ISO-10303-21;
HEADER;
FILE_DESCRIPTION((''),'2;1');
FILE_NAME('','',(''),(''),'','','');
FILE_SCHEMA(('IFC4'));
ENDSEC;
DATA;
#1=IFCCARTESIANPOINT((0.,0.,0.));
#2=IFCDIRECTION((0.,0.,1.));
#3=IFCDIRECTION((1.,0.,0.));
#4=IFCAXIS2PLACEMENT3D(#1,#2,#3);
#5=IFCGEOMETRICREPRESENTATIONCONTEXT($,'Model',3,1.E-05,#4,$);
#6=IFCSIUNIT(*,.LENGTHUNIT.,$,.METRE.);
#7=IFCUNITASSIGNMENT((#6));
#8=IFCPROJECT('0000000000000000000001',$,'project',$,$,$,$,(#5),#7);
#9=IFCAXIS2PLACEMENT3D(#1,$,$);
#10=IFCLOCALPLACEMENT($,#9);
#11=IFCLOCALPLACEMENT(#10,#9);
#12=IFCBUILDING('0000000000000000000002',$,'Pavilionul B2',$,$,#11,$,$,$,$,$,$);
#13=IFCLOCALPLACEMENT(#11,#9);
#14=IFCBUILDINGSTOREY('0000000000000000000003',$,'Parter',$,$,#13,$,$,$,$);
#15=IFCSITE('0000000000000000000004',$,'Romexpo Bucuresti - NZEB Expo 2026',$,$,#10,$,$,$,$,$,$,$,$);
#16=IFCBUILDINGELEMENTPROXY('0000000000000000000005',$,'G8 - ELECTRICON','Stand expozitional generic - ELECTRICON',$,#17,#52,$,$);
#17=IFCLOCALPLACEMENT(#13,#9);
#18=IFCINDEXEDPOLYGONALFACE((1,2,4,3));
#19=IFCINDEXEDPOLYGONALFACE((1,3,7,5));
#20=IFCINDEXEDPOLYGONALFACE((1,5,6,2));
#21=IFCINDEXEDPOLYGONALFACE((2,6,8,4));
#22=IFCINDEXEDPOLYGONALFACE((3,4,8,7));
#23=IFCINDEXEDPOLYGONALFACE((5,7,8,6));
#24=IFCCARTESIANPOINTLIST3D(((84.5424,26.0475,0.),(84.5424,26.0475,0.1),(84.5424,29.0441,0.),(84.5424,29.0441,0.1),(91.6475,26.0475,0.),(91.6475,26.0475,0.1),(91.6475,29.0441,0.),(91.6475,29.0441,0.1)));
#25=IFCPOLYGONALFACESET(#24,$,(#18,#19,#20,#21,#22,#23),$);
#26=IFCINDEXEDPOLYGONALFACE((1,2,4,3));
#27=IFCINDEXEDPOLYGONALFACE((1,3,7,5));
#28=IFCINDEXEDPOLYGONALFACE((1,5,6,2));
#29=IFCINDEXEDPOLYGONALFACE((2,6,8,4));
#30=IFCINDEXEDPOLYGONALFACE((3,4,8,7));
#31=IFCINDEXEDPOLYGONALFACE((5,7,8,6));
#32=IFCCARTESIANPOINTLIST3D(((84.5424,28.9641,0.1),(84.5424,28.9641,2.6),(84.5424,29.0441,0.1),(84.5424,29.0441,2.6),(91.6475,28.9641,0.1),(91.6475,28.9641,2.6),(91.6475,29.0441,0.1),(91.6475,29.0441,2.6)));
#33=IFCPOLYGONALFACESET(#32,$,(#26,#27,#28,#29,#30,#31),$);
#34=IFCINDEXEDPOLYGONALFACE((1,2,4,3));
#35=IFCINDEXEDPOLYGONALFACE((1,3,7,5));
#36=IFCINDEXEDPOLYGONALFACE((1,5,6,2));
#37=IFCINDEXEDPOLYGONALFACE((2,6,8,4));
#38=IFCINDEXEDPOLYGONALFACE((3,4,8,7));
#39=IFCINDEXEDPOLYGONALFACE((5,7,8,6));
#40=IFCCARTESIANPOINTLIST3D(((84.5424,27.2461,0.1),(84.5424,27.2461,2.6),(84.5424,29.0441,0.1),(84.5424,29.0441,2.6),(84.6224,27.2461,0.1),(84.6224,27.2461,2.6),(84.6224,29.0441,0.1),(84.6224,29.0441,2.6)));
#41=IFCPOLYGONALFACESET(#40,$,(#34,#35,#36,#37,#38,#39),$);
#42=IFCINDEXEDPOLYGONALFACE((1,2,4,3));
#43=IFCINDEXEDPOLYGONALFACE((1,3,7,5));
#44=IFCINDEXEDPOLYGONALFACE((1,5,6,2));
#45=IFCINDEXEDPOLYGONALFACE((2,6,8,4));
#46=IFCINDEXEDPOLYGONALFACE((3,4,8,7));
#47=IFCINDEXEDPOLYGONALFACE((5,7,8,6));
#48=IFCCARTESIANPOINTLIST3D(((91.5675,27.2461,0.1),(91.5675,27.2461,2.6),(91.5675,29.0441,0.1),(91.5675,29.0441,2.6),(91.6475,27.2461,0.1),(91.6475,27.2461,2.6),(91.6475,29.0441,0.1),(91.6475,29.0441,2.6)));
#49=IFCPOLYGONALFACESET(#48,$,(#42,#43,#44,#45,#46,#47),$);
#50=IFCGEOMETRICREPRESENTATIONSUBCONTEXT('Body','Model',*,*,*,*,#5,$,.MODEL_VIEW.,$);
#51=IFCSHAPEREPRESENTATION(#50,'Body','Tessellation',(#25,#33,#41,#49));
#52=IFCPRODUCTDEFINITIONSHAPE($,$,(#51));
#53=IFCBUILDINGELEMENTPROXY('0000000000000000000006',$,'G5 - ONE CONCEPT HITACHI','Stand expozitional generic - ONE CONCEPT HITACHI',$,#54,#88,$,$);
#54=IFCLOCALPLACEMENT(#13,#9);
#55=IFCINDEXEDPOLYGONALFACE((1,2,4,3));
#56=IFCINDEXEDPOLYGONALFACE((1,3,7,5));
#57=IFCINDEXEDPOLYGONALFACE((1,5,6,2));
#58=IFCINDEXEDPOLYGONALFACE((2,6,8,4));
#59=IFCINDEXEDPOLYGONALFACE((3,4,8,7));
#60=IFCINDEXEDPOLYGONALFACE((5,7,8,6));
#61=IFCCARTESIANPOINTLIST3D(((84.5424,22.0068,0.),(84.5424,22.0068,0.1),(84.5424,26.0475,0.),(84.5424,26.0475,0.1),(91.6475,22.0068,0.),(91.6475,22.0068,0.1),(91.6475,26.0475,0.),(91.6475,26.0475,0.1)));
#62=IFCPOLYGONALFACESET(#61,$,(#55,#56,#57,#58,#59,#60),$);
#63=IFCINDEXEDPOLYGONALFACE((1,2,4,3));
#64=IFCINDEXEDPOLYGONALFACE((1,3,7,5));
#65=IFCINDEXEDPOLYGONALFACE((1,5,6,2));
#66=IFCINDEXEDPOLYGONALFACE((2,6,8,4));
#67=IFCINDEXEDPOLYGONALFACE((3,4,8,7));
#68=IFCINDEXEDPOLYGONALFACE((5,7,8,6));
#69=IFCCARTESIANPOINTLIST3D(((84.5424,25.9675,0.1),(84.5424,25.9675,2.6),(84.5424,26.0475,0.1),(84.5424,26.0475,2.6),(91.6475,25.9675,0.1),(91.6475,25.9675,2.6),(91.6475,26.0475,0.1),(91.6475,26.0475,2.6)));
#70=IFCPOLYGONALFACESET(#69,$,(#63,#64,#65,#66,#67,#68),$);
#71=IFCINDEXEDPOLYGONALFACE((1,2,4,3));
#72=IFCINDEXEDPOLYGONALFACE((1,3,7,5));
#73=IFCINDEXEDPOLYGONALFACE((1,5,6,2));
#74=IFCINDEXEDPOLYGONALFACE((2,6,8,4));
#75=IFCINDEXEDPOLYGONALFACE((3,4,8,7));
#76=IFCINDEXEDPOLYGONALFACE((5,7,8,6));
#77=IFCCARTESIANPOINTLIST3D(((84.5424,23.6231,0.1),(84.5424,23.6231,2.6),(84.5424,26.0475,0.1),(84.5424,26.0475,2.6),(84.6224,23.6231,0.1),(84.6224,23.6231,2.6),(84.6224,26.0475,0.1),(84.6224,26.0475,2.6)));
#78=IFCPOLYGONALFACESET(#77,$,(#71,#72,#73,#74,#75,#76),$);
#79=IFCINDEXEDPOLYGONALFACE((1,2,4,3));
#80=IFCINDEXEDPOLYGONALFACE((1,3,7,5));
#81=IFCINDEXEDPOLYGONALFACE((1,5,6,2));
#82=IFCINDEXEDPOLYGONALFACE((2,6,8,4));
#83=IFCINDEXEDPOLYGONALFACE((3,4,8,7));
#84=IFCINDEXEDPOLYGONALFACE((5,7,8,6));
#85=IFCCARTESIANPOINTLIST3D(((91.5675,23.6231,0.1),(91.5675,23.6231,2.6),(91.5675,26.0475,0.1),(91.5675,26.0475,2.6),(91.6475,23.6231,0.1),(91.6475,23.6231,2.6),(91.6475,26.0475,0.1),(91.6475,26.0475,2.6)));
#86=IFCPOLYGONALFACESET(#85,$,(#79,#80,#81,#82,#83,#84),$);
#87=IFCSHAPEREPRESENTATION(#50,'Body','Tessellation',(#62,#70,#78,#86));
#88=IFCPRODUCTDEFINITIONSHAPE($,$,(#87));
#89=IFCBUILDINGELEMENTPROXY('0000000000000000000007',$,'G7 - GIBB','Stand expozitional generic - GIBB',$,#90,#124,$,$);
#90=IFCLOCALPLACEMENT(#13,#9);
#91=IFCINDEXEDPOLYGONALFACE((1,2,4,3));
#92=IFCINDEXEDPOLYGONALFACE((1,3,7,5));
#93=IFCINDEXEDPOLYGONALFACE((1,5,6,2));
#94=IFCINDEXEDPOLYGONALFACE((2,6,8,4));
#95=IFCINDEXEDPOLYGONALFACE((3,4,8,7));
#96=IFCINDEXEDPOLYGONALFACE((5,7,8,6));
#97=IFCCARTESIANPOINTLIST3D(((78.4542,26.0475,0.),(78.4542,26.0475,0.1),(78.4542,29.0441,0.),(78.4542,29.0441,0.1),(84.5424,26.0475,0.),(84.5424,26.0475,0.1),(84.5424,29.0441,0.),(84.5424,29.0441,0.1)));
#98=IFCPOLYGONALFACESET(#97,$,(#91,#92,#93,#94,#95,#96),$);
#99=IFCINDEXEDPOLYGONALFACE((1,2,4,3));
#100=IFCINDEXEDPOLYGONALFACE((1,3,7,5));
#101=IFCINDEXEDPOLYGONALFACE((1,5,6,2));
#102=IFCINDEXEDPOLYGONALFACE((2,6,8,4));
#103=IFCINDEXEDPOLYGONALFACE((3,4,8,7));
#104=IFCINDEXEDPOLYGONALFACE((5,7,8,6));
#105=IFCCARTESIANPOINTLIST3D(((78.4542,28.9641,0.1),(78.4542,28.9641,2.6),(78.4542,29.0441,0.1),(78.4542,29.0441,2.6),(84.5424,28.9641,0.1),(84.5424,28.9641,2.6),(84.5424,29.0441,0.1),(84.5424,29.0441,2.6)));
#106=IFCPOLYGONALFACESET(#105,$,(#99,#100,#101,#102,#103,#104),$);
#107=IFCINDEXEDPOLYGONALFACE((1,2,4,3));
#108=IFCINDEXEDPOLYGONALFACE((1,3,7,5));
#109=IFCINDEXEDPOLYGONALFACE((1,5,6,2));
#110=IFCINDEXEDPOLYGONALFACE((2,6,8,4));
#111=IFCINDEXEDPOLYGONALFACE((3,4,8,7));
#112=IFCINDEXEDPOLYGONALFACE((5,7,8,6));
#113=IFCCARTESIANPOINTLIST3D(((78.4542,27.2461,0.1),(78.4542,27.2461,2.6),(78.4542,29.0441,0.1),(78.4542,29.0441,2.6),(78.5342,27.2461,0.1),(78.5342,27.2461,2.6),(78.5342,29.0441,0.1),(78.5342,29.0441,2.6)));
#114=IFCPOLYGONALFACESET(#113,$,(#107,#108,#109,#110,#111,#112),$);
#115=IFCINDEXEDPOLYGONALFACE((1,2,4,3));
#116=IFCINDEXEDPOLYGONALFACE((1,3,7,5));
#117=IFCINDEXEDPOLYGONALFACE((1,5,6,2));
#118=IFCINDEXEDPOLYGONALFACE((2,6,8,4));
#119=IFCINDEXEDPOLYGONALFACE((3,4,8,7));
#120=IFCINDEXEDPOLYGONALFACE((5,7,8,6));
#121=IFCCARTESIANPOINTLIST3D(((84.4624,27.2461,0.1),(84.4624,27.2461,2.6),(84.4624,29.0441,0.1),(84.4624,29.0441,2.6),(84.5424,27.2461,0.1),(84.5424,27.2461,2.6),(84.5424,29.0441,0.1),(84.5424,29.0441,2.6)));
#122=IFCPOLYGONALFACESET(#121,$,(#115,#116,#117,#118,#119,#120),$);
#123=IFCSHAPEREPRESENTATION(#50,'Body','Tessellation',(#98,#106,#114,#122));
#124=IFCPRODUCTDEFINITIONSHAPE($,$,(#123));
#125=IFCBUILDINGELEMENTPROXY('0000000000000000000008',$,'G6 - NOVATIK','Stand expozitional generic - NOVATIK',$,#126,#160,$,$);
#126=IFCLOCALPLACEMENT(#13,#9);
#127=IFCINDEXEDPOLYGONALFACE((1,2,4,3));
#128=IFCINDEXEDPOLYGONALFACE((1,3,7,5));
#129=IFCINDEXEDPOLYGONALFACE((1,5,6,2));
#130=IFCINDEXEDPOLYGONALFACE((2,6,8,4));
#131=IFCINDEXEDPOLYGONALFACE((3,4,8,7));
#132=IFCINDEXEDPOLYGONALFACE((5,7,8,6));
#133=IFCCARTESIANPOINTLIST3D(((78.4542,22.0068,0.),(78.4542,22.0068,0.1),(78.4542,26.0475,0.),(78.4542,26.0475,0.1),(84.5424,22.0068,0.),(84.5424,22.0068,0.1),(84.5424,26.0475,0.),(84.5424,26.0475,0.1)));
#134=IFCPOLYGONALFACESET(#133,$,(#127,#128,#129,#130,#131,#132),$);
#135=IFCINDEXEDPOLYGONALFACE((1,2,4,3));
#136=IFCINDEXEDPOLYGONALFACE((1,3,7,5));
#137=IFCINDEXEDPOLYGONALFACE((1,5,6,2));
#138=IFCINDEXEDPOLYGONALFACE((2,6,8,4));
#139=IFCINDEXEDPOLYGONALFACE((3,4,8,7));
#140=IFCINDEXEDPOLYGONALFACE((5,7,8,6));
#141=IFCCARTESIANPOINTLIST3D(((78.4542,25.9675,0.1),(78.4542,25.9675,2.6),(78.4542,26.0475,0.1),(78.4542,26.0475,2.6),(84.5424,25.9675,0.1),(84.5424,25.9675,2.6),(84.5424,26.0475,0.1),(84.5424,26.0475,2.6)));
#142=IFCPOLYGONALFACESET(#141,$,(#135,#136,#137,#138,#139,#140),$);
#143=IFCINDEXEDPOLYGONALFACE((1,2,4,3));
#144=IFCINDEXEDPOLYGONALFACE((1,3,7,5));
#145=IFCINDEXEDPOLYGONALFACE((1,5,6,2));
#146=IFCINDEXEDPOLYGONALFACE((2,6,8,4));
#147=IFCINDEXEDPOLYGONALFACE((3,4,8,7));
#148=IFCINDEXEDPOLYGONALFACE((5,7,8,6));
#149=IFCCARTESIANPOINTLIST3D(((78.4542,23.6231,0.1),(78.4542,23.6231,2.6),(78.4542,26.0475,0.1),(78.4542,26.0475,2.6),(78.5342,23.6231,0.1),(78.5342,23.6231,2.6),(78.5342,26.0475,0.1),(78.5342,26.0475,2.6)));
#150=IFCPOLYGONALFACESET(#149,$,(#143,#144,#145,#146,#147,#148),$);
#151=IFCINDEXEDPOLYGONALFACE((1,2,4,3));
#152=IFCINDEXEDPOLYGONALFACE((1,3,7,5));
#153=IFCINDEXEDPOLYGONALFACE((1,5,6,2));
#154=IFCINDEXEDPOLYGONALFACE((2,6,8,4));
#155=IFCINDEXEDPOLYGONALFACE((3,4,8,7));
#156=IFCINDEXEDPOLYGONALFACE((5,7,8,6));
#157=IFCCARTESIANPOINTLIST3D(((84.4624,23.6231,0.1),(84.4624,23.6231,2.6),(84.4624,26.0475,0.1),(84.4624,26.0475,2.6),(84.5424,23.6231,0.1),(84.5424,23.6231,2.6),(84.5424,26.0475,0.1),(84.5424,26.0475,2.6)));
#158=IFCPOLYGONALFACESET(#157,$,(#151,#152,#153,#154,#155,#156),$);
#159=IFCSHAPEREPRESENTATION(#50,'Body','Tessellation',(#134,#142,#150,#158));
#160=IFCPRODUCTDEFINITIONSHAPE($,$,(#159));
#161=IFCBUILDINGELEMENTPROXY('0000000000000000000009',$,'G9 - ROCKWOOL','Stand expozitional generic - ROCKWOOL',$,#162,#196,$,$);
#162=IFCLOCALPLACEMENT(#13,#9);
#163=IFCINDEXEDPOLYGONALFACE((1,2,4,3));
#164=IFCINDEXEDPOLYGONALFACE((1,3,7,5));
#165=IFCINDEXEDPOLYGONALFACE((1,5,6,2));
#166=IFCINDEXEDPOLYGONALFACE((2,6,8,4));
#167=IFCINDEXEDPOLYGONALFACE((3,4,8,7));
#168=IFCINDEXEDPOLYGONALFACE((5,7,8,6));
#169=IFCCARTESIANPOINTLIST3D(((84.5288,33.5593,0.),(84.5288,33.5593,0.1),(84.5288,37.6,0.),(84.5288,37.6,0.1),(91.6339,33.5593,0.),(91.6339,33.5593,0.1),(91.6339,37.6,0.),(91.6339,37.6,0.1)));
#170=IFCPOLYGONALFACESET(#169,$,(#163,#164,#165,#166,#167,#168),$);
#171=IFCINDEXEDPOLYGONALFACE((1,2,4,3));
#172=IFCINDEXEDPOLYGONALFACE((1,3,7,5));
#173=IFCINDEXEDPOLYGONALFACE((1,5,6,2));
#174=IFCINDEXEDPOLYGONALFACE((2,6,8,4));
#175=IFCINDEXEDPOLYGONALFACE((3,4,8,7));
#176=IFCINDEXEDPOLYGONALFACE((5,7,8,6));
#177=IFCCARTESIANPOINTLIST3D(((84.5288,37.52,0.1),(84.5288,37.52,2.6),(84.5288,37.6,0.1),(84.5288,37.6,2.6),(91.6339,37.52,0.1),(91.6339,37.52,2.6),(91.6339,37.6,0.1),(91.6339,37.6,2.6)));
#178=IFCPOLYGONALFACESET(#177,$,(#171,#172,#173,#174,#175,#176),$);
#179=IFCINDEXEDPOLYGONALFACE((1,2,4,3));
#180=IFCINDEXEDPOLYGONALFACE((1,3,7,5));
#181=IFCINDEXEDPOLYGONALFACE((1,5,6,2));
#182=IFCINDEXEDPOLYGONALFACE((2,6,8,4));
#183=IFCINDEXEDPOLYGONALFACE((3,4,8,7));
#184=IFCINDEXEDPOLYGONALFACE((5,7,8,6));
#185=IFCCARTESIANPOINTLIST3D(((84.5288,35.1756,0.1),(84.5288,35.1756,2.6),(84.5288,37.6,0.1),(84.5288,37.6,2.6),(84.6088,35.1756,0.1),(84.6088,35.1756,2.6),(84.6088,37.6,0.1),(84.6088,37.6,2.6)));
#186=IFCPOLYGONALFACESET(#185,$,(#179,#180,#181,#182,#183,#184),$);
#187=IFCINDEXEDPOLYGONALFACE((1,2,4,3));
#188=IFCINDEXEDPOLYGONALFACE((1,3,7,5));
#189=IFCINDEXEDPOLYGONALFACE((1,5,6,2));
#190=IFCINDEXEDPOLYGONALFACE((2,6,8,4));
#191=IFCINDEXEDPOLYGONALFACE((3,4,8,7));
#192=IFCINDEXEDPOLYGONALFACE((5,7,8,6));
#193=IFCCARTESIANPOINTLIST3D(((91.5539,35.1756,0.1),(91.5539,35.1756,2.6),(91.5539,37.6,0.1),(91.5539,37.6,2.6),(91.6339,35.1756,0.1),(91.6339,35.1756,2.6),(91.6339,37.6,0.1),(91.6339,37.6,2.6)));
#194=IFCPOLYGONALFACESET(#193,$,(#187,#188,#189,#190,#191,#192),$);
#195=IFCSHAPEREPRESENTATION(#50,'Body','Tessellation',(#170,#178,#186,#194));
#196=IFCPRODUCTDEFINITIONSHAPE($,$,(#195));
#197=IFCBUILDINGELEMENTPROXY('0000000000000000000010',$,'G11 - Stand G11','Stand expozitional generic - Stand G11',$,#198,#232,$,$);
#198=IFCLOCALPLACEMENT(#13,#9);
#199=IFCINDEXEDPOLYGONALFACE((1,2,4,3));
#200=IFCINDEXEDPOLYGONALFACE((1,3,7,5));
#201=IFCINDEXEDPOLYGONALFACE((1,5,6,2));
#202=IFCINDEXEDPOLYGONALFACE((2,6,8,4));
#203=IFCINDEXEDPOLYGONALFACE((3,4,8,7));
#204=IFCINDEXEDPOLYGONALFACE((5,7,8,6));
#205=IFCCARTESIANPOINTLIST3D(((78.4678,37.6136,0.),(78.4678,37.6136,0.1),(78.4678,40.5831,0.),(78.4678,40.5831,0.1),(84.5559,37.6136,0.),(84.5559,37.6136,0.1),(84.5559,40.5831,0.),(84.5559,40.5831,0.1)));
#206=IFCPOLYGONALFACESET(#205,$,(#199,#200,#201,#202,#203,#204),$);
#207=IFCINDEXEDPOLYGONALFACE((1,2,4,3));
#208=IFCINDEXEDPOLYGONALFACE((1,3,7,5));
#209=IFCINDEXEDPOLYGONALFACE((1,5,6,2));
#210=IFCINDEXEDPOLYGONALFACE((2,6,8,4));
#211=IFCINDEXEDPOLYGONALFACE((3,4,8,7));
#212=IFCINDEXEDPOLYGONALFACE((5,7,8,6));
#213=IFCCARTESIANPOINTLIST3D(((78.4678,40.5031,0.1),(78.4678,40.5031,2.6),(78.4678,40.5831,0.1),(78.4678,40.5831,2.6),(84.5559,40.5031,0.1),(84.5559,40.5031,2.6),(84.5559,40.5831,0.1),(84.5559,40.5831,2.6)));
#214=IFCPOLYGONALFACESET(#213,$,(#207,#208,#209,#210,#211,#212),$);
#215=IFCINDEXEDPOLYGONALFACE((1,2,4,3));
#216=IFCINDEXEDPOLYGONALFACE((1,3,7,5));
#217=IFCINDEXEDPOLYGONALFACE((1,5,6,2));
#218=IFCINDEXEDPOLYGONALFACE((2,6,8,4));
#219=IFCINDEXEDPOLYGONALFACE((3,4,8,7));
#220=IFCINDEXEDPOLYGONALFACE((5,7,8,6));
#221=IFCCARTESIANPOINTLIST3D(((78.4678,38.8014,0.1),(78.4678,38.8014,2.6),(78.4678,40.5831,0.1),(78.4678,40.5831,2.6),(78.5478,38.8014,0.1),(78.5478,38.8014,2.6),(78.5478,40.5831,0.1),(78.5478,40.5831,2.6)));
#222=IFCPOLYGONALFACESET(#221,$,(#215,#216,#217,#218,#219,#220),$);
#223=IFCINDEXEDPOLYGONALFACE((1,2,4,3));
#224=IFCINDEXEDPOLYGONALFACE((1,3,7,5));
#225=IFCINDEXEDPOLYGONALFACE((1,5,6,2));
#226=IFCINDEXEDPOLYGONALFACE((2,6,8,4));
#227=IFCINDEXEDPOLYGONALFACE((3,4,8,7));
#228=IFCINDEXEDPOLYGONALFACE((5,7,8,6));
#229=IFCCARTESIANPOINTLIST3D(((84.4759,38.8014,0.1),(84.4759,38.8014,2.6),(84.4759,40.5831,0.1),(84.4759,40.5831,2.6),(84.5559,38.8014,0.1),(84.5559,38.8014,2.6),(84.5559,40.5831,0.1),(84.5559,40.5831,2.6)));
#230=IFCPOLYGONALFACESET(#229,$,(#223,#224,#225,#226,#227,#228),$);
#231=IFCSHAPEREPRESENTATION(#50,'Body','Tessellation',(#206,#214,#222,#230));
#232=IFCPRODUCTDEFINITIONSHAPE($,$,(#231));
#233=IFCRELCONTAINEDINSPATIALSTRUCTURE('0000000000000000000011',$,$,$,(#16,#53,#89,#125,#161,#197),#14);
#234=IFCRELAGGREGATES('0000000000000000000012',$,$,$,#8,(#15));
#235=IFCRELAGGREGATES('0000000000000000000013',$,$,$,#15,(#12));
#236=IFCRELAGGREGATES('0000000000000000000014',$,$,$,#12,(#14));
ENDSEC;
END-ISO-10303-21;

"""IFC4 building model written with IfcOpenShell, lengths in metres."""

from ifc_helpers import new_model, si_unit, frame, frame_2d, origin, origin_with_axes, place, context, subcontext, project, spatial, rectangle, extrude, element, save


model = new_model("IFC4")

# Units and contexts
model_context = context("Model", 3, precision=1e-05, world=origin_with_axes())
body_context = subcontext(model_context, "Body", "Model", "MODEL_VIEW")
ifc_project = project(units=[si_unit("LENGTHUNIT", "METRE")], contexts=[model_context])

# Site, building, storey
site_placement = place(None, origin())
site = spatial("IfcSite", under=ifc_project, at=site_placement, Name="Romexpo Bucuresti - NZEB Expo 2026")
building_placement = place(site_placement, origin())
building = spatial("IfcBuilding", under=site, at=building_placement, Name="Pavilionul B2")
storey_placement = place(building_placement, origin())
storey = spatial("IfcBuildingStorey", under=building, at=storey_placement, Name="Parter")

# Building element proxies
proxy_1_placement = place(storey_placement, frame((84.5424, 26.0475, 0.0), z_axis=(0.0, 0.0, 1.0), x_axis=(1.0, 0.0, 0.0)))
element("IfcBuildingElementProxy", 1, at=proxy_1_placement, inside=storey, Name="G8 - ELECTRICON", Description="Stand expozitional generic - ELECTRICON", context=body_context, shape_type="SweptSolid", body=[
    extrude(rectangle(XDim=7.1051, YDim=2.9966, at=frame_2d((3.5525, 1.4983))), origin(), (0.0, 0.0, 1.0), 0.1),
    extrude(rectangle(XDim=7.1051, YDim=0.08, at=frame_2d((3.5525, 2.9566))), frame((0.0, 0.0, 0.1)), (0.0, 0.0, 1.0), 2.5),
    extrude(rectangle(XDim=0.08, YDim=1.798, at=frame_2d((0.04, 2.0976))), frame((0.0, 0.0, 0.1)), (0.0, 0.0, 1.0), 2.5),
    extrude(rectangle(XDim=0.08, YDim=1.798, at=frame_2d((7.0651, 2.0976))), frame((0.0, 0.0, 0.1)), (0.0, 0.0, 1.0), 2.5),
])
proxy_2_placement = place(storey_placement, frame((84.5424, 22.0068, 0.0), z_axis=(0.0, 0.0, 1.0), x_axis=(1.0, 0.0, 0.0)))
element("IfcBuildingElementProxy", 2, at=proxy_2_placement, inside=storey, Name="G5 - ONE CONCEPT HITACHI", Description="Stand expozitional generic - ONE CONCEPT HITACHI", context=body_context, shape_type="SweptSolid", body=[
    extrude(rectangle(XDim=7.1051, YDim=4.0407, at=frame_2d((3.5525, 2.0203))), origin(), (0.0, 0.0, 1.0), 0.1),
    extrude(rectangle(XDim=7.1051, YDim=0.08, at=frame_2d((3.5525, 4.0007))), frame((0.0, 0.0, 0.1)), (0.0, 0.0, 1.0), 2.5),
    extrude(rectangle(XDim=0.08, YDim=2.4244, at=frame_2d((0.04, 2.8285))), frame((0.0, 0.0, 0.1)), (0.0, 0.0, 1.0), 2.5),
    extrude(rectangle(XDim=0.08, YDim=2.4244, at=frame_2d((7.0651, 2.8285))), frame((0.0, 0.0, 0.1)), (0.0, 0.0, 1.0), 2.5),
])
proxy_3_placement = place(storey_placement, frame((78.4542, 26.0475, 0.0), z_axis=(0.0, 0.0, 1.0), x_axis=(1.0, 0.0, 0.0)))
element("IfcBuildingElementProxy", 3, at=proxy_3_placement, inside=storey, Name="G7 - GIBB", Description="Stand expozitional generic - GIBB", context=body_context, shape_type="SweptSolid", body=[
    extrude(rectangle(XDim=6.0881, YDim=2.9966, at=frame_2d((3.0441, 1.4983))), origin(), (0.0, 0.0, 1.0), 0.1),
    extrude(rectangle(XDim=6.0881, YDim=0.08, at=frame_2d((3.0441, 2.9566))), frame((0.0, 0.0, 0.1)), (0.0, 0.0, 1.0), 2.5),
    extrude(rectangle(XDim=0.08, YDim=1.798, at=frame_2d((0.04, 2.0976))), frame((0.0, 0.0, 0.1)), (0.0, 0.0, 1.0), 2.5),
    extrude(rectangle(XDim=0.08, YDim=1.798, at=frame_2d((6.0481, 2.0976))), frame((0.0, 0.0, 0.1)), (0.0, 0.0, 1.0), 2.5),
])
proxy_4_placement = place(storey_placement, frame((78.4542, 22.0068, 0.0), z_axis=(0.0, 0.0, 1.0), x_axis=(1.0, 0.0, 0.0)))
element("IfcBuildingElementProxy", 4, at=proxy_4_placement, inside=storey, Name="G6 - NOVATIK", Description="Stand expozitional generic - NOVATIK", context=body_context, shape_type="SweptSolid", body=[
    extrude(rectangle(XDim=6.0881, YDim=4.0407, at=frame_2d((3.0441, 2.0203))), origin(), (0.0, 0.0, 1.0), 0.1),
    extrude(rectangle(XDim=6.0881, YDim=0.08, at=frame_2d((3.0441, 4.0007))), frame((0.0, 0.0, 0.1)), (0.0, 0.0, 1.0), 2.5),
    extrude(rectangle(XDim=0.08, YDim=2.4244, at=frame_2d((0.04, 2.8285))), frame((0.0, 0.0, 0.1)), (0.0, 0.0, 1.0), 2.5),
    extrude(rectangle(XDim=0.08, YDim=2.4244, at=frame_2d((6.0481, 2.8285))), frame((0.0, 0.0, 0.1)), (0.0, 0.0, 1.0), 2.5),
])
proxy_5_placement = place(storey_placement, frame((84.5288, 33.5593, 0.0), z_axis=(0.0, 0.0, 1.0), x_axis=(1.0, 0.0, 0.0)))
element("IfcBuildingElementProxy", 5, at=proxy_5_placement, inside=storey, Name="G9 - ROCKWOOL", Description="Stand expozitional generic - ROCKWOOL", context=body_context, shape_type="SweptSolid", body=[
    extrude(rectangle(XDim=7.1051, YDim=4.0407, at=frame_2d((3.5525, 2.0203))), origin(), (0.0, 0.0, 1.0), 0.1),
    extrude(rectangle(XDim=7.1051, YDim=0.08, at=frame_2d((3.5525, 4.0007))), frame((0.0, 0.0, 0.1)), (0.0, 0.0, 1.0), 2.5),
    extrude(rectangle(XDim=0.08, YDim=2.4244, at=frame_2d((0.04, 2.8285))), frame((0.0, 0.0, 0.1)), (0.0, 0.0, 1.0), 2.5),
    extrude(rectangle(XDim=0.08, YDim=2.4244, at=frame_2d((7.0651, 2.8285))), frame((0.0, 0.0, 0.1)), (0.0, 0.0, 1.0), 2.5),
])
proxy_6_placement = place(storey_placement, frame((78.4678, 37.6136, 0.0), z_axis=(0.0, 0.0, 1.0), x_axis=(1.0, 0.0, 0.0)))
element("IfcBuildingElementProxy", 6, at=proxy_6_placement, inside=storey, Name="G11 - Stand G11", Description="Stand expozitional generic - Stand G11", context=body_context, shape_type="SweptSolid", body=[
    extrude(rectangle(XDim=6.0881, YDim=2.9695, at=frame_2d((3.0441, 1.4847))), origin(), (0.0, 0.0, 1.0), 0.1),
    extrude(rectangle(XDim=6.0881, YDim=0.08, at=frame_2d((3.0441, 2.9295))), frame((0.0, 0.0, 0.1)), (0.0, 0.0, 1.0), 2.5),
    extrude(rectangle(XDim=0.08, YDim=1.7817, at=frame_2d((0.04, 2.0786))), frame((0.0, 0.0, 0.1)), (0.0, 0.0, 1.0), 2.5),
    extrude(rectangle(XDim=0.08, YDim=1.7817, at=frame_2d((6.0481, 2.0786))), frame((0.0, 0.0, 0.1)), (0.0, 0.0, 1.0), 2.5),
])

save(model, "model.ifc")
